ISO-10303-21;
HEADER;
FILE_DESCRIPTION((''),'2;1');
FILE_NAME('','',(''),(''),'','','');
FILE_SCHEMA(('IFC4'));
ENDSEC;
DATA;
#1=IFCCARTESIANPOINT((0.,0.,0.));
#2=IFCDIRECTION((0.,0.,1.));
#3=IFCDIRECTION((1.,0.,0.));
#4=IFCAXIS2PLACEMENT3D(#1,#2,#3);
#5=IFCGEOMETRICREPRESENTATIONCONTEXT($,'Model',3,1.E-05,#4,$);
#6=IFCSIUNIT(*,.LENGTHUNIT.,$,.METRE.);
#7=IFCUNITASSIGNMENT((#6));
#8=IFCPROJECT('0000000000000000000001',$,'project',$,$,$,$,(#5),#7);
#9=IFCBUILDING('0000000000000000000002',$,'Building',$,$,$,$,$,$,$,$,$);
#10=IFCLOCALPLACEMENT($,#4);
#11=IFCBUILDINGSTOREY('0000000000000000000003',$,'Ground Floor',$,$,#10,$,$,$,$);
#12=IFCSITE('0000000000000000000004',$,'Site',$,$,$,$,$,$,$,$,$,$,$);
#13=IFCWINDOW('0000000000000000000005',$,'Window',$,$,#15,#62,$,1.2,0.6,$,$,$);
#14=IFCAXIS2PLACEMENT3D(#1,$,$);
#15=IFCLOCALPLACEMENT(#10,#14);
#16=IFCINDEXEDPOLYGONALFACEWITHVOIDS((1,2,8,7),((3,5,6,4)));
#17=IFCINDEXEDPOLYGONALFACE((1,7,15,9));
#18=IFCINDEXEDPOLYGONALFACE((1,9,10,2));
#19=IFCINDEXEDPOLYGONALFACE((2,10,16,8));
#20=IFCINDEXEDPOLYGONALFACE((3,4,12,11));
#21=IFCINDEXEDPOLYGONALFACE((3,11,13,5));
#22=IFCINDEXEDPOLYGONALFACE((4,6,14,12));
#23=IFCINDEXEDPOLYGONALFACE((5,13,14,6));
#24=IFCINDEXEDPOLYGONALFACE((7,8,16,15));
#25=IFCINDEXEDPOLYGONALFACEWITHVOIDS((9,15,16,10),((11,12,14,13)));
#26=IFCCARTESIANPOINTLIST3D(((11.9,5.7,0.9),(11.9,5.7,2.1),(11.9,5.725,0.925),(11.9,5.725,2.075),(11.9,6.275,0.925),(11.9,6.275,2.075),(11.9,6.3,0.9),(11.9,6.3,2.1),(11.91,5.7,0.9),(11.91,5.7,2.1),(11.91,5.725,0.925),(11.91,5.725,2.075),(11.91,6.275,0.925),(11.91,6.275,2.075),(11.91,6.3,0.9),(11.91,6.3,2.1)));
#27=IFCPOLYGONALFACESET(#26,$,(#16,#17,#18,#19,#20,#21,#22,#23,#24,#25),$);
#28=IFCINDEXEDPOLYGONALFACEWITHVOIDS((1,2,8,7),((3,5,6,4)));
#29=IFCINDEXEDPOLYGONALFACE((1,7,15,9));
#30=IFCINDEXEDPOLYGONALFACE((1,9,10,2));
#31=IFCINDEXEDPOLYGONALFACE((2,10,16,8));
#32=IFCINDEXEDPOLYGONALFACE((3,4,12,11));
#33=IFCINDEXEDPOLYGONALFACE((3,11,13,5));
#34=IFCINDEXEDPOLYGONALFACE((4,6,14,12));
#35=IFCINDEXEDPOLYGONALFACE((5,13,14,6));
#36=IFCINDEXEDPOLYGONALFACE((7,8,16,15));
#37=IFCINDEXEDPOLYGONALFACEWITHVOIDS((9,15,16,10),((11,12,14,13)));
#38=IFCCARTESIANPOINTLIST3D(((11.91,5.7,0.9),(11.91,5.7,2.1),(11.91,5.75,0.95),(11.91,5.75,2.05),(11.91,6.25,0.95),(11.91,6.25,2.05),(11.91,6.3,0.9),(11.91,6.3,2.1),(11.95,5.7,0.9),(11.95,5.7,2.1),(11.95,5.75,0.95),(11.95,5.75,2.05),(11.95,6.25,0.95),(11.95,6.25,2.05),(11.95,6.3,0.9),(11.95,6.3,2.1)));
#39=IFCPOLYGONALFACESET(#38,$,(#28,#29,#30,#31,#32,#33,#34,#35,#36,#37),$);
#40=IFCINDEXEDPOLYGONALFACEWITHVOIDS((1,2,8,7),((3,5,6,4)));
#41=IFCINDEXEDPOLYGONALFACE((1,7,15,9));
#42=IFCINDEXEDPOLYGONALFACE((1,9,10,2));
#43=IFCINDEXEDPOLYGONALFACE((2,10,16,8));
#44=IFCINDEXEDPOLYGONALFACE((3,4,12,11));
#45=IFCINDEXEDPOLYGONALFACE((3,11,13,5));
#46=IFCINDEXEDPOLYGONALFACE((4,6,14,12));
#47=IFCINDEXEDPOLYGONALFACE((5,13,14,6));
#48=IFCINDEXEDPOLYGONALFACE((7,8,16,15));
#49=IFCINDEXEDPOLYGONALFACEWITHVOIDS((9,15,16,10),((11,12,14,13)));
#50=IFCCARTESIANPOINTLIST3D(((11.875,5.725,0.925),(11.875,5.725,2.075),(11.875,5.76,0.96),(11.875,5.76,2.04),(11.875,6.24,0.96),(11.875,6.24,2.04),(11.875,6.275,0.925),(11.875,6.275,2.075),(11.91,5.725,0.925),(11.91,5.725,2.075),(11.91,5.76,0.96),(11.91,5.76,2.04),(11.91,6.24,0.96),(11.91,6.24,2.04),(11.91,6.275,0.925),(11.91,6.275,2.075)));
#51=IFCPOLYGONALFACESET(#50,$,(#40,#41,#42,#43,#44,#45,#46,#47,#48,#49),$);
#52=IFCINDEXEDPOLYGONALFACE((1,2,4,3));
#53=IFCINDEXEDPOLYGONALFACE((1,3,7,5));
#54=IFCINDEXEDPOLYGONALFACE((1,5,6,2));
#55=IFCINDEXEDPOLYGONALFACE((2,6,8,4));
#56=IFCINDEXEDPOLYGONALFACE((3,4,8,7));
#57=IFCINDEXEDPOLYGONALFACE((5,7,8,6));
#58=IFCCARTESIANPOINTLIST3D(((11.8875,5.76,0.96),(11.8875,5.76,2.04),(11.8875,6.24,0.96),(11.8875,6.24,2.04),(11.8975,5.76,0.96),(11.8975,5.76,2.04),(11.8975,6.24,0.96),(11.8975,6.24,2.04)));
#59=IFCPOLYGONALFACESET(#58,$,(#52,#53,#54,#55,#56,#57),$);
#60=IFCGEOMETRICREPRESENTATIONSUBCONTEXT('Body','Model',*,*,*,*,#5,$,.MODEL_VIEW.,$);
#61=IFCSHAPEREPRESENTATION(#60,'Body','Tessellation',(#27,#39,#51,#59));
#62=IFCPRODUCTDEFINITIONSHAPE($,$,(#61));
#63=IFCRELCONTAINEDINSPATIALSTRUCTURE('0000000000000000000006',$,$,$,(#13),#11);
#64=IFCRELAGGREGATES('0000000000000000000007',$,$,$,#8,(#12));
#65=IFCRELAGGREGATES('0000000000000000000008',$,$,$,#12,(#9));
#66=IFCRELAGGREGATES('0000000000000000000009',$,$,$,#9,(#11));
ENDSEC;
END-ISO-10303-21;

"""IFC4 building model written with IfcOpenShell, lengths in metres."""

from ifc_helpers import new_model, si_unit, frame, origin_with_axes, place, context, subcontext, project, spatial, line, indexed_curve, outline, extrude, element, save


model = new_model("IFC4")

# Units and contexts
model_context = context("Model", 3, precision=1e-05, world=origin_with_axes())
body_context = subcontext(model_context, "Body", "Model", "MODEL_VIEW")
ifc_project = project(units=[si_unit("LENGTHUNIT", "METRE")], contexts=[model_context])

# Site, building, storey
site = spatial("IfcSite", under=ifc_project, Name="Site")
building = spatial("IfcBuilding", under=site, Name="Building")
storey_placement = place(None, origin_with_axes())
storey = spatial("IfcBuildingStorey", under=building, at=storey_placement, Name="Ground Floor")

# Window
window_1_placement = place(storey_placement, frame((12.0, 5.7, 0.9), z_axis=(0.0, 0.0, 1.0), x_axis=(0.0, 1.0, 0.0)))
element("IfcWindow", 1, at=window_1_placement, inside=storey, Name="Window", OverallHeight=1.2, OverallWidth=0.6, context=body_context, shape_type="SweptSolid", body=[
    extrude(outline(indexed_curve([(0.0, 0.0), (0.6, 0.0), (0.6, 1.2), (0.0, 1.2)], segments=[line(1, 2, 3, 4, 1)]), holes=[indexed_curve([(0.025, 0.025), (0.575, 0.025), (0.575, 1.175), (0.025, 1.175)], segments=[line(1, 2, 3, 4, 1)])]), frame((0.0, 0.09, 0.0), z_axis=(0.0, -1.0, 0.0), x_axis=(1.0, 0.0, 0.0)), (0.0, 0.0, -1.0), 0.01),
    extrude(outline(indexed_curve([(0.0, 0.0), (0.6, 0.0), (0.6, 1.2), (0.0, 1.2)], segments=[line(1, 2, 3, 4, 1)]), holes=[indexed_curve([(0.05, 0.05), (0.55, 0.05), (0.55, 1.15), (0.05, 1.15)], segments=[line(1, 2, 3, 4, 1)])]), frame((0.0, 0.05, 0.0), z_axis=(0.0, -1.0, 0.0), x_axis=(1.0, 0.0, 0.0)), (0.0, 0.0, -1.0), 0.04),
    extrude(outline(indexed_curve([(0.0, 0.0), (0.55, 0.0), (0.55, 1.15), (0.0, 1.15)], segments=[line(1, 2, 3, 4, 1)]), holes=[indexed_curve([(0.035, 0.035), (0.515, 0.035), (0.515, 1.115), (0.035, 1.115)], segments=[line(1, 2, 3, 4, 1)])]), frame((0.025, 0.09, 0.025), z_axis=(0.0, -1.0, 0.0), x_axis=(1.0, 0.0, 0.0)), (0.0, 0.0, -1.0), 0.035),
    extrude(outline(indexed_curve([(0.035, 0.035), (0.515, 0.035), (0.515, 1.115), (0.035, 1.115)], segments=[line(1, 2, 3, 4, 1)])), frame((0.025, 0.1025, 0.025), z_axis=(0.0, -1.0, 0.0), x_axis=(1.0, 0.0, 0.0)), (0.0, 0.0, -1.0), 0.01),
])

save(model, "model.ifc")
